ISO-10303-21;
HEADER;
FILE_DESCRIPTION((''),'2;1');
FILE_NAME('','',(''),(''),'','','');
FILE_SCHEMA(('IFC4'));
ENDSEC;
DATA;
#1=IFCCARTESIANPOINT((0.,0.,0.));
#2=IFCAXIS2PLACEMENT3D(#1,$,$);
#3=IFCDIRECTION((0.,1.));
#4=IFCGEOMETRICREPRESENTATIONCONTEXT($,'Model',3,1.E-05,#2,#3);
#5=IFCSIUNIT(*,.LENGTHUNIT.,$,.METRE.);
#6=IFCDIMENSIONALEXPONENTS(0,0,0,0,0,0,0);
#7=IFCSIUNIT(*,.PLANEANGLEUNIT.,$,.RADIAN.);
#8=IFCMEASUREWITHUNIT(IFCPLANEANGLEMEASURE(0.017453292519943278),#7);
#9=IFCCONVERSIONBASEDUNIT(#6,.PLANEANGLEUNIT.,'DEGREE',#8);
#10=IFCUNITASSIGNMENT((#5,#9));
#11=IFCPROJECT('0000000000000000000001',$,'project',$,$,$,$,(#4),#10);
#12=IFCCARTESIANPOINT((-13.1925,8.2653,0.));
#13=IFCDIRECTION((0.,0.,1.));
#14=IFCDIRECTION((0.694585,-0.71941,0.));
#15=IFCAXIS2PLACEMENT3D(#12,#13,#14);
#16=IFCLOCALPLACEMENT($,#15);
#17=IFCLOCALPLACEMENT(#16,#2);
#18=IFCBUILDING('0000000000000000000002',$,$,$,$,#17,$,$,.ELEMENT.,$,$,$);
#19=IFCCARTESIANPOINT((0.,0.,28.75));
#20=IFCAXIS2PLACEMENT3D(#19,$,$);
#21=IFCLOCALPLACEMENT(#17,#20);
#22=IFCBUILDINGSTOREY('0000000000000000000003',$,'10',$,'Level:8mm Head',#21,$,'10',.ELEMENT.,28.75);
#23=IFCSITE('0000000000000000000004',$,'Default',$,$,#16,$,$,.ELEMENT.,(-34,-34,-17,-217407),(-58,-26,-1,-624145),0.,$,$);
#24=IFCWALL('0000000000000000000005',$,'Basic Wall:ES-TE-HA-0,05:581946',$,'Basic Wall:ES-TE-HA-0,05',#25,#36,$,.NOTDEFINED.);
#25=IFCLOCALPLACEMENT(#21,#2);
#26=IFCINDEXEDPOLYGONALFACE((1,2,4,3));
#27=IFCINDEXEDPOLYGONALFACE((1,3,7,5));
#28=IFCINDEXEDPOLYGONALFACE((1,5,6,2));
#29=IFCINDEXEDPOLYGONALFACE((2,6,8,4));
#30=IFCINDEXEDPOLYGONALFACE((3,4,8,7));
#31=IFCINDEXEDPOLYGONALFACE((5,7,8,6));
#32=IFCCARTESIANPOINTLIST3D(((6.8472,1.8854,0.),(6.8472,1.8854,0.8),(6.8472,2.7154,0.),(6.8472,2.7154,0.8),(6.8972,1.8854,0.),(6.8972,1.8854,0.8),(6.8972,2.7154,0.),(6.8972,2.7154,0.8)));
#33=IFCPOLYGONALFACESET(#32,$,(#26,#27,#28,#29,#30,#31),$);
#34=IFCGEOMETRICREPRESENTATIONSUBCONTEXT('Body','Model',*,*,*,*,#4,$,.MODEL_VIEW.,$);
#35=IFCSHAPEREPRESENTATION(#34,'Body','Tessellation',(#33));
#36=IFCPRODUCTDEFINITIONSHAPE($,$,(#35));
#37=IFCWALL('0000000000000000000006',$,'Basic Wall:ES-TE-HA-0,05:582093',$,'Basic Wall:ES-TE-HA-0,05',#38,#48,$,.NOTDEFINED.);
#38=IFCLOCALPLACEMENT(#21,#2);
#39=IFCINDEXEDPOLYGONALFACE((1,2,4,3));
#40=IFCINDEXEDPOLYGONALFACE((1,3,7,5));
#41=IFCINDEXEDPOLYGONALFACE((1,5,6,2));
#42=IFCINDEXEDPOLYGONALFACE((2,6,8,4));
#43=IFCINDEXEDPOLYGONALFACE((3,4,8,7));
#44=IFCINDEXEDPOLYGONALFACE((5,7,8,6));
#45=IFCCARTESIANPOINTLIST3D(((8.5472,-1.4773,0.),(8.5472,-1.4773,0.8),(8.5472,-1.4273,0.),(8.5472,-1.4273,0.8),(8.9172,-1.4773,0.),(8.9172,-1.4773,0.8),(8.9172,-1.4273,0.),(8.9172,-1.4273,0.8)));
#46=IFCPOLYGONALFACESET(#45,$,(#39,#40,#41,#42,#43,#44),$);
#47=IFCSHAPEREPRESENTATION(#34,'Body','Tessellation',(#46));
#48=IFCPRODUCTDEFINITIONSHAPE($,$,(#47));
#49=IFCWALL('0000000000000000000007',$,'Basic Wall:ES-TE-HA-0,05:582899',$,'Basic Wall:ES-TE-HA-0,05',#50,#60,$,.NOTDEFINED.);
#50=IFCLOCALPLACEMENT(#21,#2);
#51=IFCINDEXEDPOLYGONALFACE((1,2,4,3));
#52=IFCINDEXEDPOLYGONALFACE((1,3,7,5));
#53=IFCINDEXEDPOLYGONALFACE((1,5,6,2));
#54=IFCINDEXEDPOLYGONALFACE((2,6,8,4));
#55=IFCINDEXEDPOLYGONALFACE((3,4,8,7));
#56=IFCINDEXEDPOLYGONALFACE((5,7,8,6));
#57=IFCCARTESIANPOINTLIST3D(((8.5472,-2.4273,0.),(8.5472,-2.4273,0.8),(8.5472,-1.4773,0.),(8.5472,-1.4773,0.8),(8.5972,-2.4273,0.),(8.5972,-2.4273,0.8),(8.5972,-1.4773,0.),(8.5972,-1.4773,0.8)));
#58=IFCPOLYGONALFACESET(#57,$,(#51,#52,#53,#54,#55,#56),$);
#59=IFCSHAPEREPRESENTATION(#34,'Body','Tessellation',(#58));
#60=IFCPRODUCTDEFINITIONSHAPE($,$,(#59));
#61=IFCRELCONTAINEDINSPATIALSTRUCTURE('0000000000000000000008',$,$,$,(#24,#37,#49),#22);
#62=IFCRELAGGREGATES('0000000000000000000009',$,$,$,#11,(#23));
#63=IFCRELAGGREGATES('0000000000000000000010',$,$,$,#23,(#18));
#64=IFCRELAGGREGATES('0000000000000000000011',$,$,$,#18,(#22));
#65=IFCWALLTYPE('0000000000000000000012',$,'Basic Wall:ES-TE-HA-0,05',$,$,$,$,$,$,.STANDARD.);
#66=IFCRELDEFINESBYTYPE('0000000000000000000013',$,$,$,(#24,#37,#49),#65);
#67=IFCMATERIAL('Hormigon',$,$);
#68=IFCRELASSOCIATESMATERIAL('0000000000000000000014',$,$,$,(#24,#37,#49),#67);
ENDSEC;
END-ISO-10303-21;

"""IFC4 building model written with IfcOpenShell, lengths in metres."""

from ifc_helpers import new_model, entity, si_unit, converted_unit, direction, frame, origin, place, context, subcontext, project, spatial, indexed_curve, outline, extrude, material, type_object, element, save


model = new_model("IFC4")

# Units and contexts
model_context = context("Model", 3, precision=1e-05, world=origin(), true_north=direction((0.0, 1.0)))
body_context = subcontext(model_context, "Body", "Model", "MODEL_VIEW")
ifc_project = project(units=[si_unit("LENGTHUNIT", "METRE"), converted_unit("PLANEANGLEUNIT", "DEGREE", entity("IfcPlaneAngleMeasure", 0.017453292519943278), si_unit("PLANEANGLEUNIT", "RADIAN"), dimensions=[0, 0, 0, 0, 0, 0, 0])], contexts=[model_context])

# Site, building, storey
site_placement = place(None, frame((-13.1925, 8.2653, 0.0), z_axis=(0.0, 0.0, 1.0), x_axis=(0.694585, -0.71941, 0.0)))
site = spatial("IfcSite", under=ifc_project, at=site_placement, Name="Default", CompositionType="ELEMENT", RefLatitude=(-34, -34, -17, -217407), RefLongitude=(-58, -26, -1, -624145), RefElevation=0.0)
building_placement = place(site_placement, origin())
building = spatial("IfcBuilding", under=site, at=building_placement, CompositionType="ELEMENT")
storey_placement = place(building_placement, frame((0.0, 0.0, 28.75)))
storey = spatial("IfcBuildingStorey", under=building, at=storey_placement, Name="10", ObjectType="Level:8mm Head", LongName="10", CompositionType="ELEMENT", Elevation=28.75)

# Shared definitions
ifc_material_1 = material(Name="Hormigon")

# Walls
wall_type_1 = type_object("IfcWallType", Name="Basic Wall:ES-TE-HA-0,05", PredefinedType="STANDARD")
wall_1_placement = place(storey_placement, frame((6.8722, 1.8854, 0.0), z_axis=(0.0, 0.0, 1.0), x_axis=(0.0, 1.0, 0.0)))
element("IfcWall", 1, at=wall_1_placement, inside=storey, type_object=wall_type_1, material=ifc_material_1, Name="Basic Wall:ES-TE-HA-0,05:581946", ObjectType="Basic Wall:ES-TE-HA-0,05", PredefinedType="NOTDEFINED", context=body_context, shape_type="SweptSolid", body=[
    extrude(outline(indexed_curve([(0.83, 0.025), (0.0, 0.025), (0.0, -0.025), (0.83, -0.025), (0.83, 0.025)], self_intersect=False)), origin(), (0.0, 0.0, 1.0), 0.8),
])
wall_2_placement = place(storey_placement, frame((8.5472, -1.4523, 0.0)))
element("IfcWall", 2, at=wall_2_placement, inside=storey, type_object=wall_type_1, material=ifc_material_1, Name="Basic Wall:ES-TE-HA-0,05:582093", ObjectType="Basic Wall:ES-TE-HA-0,05", PredefinedType="NOTDEFINED", context=body_context, shape_type="SweptSolid", body=[
    extrude(outline(indexed_curve([(0.37, 0.025), (0.0, 0.025), (0.0, -0.025), (0.37, -0.025), (0.37, 0.025)], self_intersect=False)), origin(), (0.0, 0.0, 1.0), 0.8),
])
wall_3_placement = place(storey_placement, frame((8.5722, -1.4773, 0.0), z_axis=(0.0, 0.0, 1.0), x_axis=(0.0, -1.0, 0.0)))
element("IfcWall", 3, at=wall_3_placement, inside=storey, type_object=wall_type_1, material=ifc_material_1, Name="Basic Wall:ES-TE-HA-0,05:582899", ObjectType="Basic Wall:ES-TE-HA-0,05", PredefinedType="NOTDEFINED", context=body_context, shape_type="SweptSolid", body=[
    extrude(outline(indexed_curve([(0.95, 0.025), (0.0, 0.025), (0.0, -0.025), (0.95, -0.025), (0.95, 0.025)], self_intersect=False)), origin(), (0.0, 0.0, 1.0), 0.8),
])

save(model, "model.ifc")
